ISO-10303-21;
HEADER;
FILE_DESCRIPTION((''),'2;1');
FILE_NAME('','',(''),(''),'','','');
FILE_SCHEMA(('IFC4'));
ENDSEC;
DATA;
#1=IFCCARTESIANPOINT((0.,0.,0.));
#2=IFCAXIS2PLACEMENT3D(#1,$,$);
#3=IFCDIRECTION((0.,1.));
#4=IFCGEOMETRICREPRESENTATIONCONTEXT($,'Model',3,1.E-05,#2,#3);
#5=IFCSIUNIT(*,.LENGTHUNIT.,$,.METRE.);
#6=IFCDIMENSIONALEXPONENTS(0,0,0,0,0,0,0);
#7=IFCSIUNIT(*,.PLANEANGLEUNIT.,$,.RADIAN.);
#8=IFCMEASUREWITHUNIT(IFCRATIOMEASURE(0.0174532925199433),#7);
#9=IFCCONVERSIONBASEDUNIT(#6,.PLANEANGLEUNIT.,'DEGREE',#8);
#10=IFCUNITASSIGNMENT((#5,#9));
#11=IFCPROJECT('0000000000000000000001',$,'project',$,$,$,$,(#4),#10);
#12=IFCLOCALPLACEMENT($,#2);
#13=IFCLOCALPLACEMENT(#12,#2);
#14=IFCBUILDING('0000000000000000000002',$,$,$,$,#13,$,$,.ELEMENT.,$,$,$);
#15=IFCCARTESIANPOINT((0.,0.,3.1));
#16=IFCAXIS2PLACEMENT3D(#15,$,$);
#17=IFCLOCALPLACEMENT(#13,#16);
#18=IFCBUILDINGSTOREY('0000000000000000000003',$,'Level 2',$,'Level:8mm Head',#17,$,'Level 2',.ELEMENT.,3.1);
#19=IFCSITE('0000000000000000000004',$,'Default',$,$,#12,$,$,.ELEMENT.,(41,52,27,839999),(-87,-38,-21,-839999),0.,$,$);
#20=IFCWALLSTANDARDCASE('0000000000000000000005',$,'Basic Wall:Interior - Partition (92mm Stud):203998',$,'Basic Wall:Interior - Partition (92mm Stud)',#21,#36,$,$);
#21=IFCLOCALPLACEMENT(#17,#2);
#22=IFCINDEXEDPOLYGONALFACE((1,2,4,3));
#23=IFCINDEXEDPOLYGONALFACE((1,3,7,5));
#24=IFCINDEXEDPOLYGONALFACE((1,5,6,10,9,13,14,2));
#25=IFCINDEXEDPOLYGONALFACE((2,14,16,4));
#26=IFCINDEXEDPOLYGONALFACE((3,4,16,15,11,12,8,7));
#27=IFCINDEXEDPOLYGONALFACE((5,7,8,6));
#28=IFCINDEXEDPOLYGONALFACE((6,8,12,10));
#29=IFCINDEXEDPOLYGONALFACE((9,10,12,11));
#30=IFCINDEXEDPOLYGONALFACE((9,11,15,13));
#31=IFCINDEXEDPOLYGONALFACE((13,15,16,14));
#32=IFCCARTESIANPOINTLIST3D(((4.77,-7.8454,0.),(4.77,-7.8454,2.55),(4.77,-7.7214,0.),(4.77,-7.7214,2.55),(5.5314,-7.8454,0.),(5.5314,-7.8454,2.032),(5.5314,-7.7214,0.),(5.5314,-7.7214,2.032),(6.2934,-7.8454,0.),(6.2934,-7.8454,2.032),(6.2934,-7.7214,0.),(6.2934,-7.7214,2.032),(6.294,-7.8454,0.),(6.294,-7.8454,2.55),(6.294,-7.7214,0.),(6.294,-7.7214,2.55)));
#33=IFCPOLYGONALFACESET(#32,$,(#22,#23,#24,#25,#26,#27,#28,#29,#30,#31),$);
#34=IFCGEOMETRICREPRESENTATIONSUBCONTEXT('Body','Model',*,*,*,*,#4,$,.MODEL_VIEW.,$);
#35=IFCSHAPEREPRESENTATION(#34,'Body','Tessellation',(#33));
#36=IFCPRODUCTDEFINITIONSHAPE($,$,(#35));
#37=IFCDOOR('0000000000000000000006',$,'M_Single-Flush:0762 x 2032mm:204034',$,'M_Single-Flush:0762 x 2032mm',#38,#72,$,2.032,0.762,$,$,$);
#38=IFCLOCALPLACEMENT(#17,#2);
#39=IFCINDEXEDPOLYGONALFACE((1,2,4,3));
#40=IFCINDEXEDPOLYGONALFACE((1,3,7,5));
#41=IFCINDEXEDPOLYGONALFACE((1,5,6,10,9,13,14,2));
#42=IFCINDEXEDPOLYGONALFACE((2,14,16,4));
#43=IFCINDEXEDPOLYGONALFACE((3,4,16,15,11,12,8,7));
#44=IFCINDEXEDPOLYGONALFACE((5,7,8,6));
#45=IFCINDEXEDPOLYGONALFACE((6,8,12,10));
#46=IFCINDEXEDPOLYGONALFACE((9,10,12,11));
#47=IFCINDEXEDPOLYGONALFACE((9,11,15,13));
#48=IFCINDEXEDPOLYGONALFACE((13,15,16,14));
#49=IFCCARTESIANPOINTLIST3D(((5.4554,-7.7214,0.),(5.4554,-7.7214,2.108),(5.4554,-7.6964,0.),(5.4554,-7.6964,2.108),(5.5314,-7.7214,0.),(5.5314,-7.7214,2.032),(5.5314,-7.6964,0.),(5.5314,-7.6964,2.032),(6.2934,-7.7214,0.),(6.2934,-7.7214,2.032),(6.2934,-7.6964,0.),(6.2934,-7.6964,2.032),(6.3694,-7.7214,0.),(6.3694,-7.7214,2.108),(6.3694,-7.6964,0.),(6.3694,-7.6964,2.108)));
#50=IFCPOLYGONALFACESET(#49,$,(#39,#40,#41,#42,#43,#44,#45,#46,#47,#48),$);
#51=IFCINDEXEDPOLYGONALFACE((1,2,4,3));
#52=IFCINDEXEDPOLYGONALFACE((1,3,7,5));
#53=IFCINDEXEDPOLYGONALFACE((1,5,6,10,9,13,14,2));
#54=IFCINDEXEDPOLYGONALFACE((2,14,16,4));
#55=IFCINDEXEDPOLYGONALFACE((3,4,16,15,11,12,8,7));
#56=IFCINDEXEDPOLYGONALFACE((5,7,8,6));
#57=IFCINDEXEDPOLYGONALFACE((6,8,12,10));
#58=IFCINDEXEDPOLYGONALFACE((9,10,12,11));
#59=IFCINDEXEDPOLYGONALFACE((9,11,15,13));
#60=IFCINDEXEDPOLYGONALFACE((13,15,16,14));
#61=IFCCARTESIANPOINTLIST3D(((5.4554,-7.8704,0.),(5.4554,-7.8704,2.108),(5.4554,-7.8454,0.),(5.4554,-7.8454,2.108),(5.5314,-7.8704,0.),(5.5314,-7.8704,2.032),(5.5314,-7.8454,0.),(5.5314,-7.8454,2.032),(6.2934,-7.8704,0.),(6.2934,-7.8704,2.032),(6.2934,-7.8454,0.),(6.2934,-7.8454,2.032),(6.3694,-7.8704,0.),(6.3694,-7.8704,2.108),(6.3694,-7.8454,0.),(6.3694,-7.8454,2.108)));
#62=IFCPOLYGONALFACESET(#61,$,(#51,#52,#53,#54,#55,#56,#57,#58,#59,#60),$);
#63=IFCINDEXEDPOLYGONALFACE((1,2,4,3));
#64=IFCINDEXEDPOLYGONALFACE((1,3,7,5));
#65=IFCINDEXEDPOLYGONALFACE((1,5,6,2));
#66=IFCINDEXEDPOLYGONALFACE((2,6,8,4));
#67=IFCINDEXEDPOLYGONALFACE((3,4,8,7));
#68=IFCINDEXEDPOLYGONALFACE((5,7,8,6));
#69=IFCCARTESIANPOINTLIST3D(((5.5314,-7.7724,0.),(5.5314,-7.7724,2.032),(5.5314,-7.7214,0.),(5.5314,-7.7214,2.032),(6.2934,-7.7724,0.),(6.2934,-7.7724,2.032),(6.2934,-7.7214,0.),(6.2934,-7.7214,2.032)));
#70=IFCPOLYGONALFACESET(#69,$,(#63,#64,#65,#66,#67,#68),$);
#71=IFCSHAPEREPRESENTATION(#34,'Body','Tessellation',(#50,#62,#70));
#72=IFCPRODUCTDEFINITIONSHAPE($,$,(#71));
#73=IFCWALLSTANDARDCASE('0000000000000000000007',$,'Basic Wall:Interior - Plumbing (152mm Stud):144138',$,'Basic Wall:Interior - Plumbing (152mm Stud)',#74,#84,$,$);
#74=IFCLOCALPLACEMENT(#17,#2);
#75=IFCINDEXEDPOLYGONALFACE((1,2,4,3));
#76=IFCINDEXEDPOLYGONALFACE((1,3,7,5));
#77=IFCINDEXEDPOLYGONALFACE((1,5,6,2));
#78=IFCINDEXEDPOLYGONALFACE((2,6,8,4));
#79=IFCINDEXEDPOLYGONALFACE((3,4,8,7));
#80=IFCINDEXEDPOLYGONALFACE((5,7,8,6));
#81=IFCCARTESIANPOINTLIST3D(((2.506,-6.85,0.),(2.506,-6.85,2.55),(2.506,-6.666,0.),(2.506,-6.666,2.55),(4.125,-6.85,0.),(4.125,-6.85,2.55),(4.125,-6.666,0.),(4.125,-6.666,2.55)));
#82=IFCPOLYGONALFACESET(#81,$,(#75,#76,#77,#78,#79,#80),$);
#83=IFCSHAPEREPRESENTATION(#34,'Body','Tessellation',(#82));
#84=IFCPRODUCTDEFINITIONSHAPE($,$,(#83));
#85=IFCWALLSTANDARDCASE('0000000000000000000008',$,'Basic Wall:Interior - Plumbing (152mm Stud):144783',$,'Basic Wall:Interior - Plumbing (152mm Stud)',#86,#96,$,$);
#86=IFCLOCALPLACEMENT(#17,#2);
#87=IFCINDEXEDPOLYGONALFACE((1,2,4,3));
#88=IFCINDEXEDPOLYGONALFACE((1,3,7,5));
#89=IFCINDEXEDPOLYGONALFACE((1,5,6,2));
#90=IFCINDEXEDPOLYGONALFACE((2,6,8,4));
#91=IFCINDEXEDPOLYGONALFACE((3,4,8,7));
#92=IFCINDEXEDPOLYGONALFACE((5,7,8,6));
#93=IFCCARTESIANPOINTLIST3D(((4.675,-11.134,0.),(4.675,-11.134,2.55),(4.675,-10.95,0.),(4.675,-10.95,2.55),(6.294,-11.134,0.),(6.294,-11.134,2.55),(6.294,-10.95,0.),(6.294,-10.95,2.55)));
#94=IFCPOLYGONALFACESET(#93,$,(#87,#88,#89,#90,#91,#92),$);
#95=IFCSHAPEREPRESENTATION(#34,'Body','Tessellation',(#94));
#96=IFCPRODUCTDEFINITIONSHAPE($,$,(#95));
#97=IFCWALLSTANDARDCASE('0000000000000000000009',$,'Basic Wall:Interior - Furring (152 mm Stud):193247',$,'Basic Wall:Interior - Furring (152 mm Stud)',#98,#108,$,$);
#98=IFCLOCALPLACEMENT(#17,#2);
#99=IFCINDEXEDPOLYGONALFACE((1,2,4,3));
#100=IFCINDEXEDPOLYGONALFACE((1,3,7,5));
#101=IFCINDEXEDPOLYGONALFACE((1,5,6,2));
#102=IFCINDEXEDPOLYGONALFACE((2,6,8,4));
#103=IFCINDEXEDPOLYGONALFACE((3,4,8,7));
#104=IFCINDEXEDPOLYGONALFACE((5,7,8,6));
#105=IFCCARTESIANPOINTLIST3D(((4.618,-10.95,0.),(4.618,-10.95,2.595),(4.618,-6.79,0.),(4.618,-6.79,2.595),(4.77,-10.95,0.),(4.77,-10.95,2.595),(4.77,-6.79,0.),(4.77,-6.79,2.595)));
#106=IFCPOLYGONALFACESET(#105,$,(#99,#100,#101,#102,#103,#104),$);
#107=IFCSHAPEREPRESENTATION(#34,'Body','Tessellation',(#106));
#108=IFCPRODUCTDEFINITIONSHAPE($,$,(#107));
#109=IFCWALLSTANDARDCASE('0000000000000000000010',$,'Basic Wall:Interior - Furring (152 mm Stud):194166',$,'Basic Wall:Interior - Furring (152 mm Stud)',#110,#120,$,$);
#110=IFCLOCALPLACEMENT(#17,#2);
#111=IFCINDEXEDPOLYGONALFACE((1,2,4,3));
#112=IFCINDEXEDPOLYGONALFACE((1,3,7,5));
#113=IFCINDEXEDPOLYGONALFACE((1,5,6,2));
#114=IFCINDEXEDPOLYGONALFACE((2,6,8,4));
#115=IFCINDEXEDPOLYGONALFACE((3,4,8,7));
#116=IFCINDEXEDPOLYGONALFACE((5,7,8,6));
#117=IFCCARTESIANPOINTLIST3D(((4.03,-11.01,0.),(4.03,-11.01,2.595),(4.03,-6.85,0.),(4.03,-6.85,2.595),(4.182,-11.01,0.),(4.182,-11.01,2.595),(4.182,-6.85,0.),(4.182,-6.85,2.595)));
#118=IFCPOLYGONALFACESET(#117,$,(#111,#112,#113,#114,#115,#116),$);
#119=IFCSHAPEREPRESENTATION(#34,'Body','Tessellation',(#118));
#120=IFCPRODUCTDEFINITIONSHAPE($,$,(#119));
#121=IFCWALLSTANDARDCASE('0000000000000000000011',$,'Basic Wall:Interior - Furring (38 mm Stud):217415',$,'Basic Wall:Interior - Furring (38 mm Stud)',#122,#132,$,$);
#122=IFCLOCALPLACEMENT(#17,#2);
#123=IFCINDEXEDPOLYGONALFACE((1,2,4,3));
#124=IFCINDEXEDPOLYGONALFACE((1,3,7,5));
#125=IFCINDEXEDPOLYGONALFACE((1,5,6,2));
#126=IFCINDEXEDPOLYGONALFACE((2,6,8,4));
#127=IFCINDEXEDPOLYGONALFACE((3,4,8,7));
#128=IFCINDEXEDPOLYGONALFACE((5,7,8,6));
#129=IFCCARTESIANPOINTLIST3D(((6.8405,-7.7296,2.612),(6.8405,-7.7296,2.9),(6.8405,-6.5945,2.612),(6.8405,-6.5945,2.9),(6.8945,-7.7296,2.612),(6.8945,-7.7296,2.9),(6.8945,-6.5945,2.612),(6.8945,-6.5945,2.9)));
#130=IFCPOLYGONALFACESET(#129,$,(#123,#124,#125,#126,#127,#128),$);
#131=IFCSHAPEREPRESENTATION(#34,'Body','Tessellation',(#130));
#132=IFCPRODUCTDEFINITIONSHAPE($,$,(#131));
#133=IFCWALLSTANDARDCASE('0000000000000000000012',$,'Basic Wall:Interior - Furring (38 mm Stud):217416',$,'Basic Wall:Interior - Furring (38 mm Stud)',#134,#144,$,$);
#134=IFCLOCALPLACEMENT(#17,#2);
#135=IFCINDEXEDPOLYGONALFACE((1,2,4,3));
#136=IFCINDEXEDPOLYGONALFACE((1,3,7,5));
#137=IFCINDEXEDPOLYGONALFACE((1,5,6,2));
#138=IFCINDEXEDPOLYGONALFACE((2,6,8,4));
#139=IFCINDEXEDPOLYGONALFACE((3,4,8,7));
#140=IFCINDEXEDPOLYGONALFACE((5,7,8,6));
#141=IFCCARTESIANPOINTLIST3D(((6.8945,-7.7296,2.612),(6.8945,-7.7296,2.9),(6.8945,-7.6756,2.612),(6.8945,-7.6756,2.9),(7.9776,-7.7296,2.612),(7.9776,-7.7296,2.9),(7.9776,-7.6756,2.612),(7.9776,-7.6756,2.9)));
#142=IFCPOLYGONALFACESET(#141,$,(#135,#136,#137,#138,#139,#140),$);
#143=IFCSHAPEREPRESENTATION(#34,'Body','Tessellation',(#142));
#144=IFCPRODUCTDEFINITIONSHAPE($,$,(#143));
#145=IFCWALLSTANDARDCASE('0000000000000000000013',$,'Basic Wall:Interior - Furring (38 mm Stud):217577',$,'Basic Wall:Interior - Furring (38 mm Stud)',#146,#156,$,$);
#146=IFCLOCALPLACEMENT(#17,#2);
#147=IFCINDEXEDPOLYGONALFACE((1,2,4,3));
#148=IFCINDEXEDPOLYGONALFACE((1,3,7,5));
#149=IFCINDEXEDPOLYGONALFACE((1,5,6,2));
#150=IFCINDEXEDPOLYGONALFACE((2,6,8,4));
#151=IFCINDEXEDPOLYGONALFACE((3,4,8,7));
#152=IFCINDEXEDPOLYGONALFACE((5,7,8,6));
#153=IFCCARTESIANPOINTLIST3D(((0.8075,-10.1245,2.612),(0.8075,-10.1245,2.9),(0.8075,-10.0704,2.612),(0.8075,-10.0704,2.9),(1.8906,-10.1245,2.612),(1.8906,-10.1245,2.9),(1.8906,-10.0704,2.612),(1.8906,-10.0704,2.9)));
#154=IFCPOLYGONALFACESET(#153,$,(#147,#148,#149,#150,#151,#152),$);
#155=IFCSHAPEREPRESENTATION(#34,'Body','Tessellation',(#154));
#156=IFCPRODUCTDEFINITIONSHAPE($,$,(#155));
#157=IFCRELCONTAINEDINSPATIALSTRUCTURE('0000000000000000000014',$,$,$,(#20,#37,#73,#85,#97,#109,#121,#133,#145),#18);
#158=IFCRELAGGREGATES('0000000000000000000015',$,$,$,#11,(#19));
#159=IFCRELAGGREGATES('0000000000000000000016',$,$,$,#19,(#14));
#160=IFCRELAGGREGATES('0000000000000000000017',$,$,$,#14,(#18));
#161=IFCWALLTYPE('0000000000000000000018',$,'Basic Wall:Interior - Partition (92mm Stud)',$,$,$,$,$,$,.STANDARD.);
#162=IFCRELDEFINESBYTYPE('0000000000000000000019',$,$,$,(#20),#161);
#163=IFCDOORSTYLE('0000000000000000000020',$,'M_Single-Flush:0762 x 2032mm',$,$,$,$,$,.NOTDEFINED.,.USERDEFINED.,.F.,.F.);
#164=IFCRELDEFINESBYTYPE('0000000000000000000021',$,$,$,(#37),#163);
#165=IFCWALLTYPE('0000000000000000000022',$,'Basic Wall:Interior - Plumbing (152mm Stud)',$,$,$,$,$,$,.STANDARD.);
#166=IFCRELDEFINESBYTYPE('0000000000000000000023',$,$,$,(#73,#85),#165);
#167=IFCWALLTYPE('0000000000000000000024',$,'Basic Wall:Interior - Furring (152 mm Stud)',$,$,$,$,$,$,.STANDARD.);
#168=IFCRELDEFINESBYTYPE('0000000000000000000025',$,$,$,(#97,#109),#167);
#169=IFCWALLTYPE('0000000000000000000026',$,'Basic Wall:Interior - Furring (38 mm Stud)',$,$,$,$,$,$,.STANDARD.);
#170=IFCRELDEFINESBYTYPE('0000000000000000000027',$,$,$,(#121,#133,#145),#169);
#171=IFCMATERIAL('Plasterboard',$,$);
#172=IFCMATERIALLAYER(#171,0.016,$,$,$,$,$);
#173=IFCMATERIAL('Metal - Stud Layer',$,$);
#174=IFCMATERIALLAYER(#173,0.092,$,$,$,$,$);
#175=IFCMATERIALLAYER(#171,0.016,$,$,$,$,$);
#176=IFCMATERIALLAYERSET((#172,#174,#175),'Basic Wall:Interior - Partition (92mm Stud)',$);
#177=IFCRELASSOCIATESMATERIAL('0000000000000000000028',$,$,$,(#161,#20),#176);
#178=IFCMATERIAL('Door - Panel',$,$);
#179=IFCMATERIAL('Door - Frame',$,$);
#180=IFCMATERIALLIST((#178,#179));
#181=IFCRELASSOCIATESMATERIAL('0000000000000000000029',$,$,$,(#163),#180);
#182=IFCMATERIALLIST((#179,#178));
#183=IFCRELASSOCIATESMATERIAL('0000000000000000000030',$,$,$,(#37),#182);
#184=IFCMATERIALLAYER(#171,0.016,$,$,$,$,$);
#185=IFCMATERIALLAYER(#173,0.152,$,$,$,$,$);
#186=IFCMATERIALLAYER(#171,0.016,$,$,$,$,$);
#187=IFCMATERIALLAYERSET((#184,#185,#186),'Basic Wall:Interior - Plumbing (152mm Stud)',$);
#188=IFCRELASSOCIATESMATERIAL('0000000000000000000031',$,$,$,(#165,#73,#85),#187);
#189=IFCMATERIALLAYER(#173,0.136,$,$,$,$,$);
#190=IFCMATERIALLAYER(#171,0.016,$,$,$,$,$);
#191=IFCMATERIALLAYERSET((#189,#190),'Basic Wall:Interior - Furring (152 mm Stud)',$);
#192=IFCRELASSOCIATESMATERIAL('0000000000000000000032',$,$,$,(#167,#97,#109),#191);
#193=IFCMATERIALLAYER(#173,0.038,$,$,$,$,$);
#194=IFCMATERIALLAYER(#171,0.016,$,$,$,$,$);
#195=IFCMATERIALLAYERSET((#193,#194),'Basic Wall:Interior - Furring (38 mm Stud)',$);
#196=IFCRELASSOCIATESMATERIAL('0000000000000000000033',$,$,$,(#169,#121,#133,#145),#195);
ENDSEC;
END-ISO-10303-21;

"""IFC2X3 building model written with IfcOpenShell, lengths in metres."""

from ifc_helpers import new_model, entity, si_unit, converted_unit, direction, frame, frame_2d, origin, origin_2d_with_axis, place, context, subcontext, project, spatial, polyline, rectangle, outline, extrude, source, transform, mapped, material, material_list, layer, layer_set, layer_usage, type_object, type_shapes, element, fill, save


model = new_model("IFC2X3")

# Units and contexts
model_context = context("Model", 3, precision=1e-05, world=origin(), true_north=direction((0.0, 1.0)))
body_context = subcontext(model_context, "Body", "Model", "MODEL_VIEW")
ifc_project = project(units=[si_unit("LENGTHUNIT", "METRE"), converted_unit("PLANEANGLEUNIT", "DEGREE", entity("IfcRatioMeasure", 0.0174532925199433), si_unit("PLANEANGLEUNIT", "RADIAN"), dimensions=[0, 0, 0, 0, 0, 0, 0])], contexts=[model_context])

# Site, building, storey
site_placement = place(None, origin())
site = spatial("IfcSite", under=ifc_project, at=site_placement, Name="Default", CompositionType="ELEMENT", RefLatitude=(41, 52, 27, 839999), RefLongitude=(-87, -38, -21, -839999), RefElevation=0.0)
building_placement = place(site_placement, origin())
building = spatial("IfcBuilding", under=site, at=building_placement, CompositionType="ELEMENT")
storey_placement = place(building_placement, frame((0.0, 0.0, 3.1)))
storey = spatial("IfcBuildingStorey", under=building, at=storey_placement, Name="Level 2", ObjectType="Level:8mm Head", LongName="Level 2", CompositionType="ELEMENT", Elevation=3.1)

# Shared definitions
ifc_material_1 = material(Name="Plasterboard")
ifc_layer_1 = layer(ifc_material_1, 0.016)
ifc_material_2 = material(Name="Metal - Stud Layer")
ifc_layer_2 = layer(ifc_material_2, 0.092)
ifc_layer_3 = layer(ifc_material_1, 0.016)
ifc_layer_set_1 = layer_set([ifc_layer_1, ifc_layer_2, ifc_layer_3], Name="Basic Wall:Interior - Partition (92mm Stud)")
wall_type_1 = type_object("IfcWallType", Name="Basic Wall:Interior - Partition (92mm Stud)", PredefinedType="STANDARD", material=ifc_layer_set_1)

# Wall, opening, door
ifc_material_3 = material(Name="Door - Frame")
ifc_material_4 = material(Name="Door - Panel")
ifc_material_list_1 = material_list([ifc_material_4, ifc_material_3])
door_style = type_object("IfcDoorStyle", Name="M_Single-Flush:0762 x 2032mm", ConstructionType="USERDEFINED", OperationType="NOTDEFINED", ParameterTakesPrecedence=False, Sizeable=False, material=ifc_material_list_1)
shared_shape_1 = source(origin(), body_context, "Body", "SweptSolid", [
    extrude(outline(polyline([(-0.457, -1.073), (0.457, -1.073), (0.457, 1.035), (0.381, 1.035), (0.381, -0.997), (-0.381, -0.997), (-0.381, 1.035), (-0.457, 1.035), (-0.457, -1.073)])), frame((0.381, 0.124, 1.035), z_axis=(0.0, 1.0, 0.0), x_axis=(1.0, 0.0, 0.0)), (0.0, 0.0, 1.0), 0.025),
    extrude(outline(polyline([(-1.073, -0.457), (1.035, -0.457), (1.035, -0.381), (-0.997, -0.381), (-0.997, 0.381), (1.035, 0.381), (1.035, 0.457), (-1.073, 0.457), (-1.073, -0.457)])), frame((0.381, -0.025, 1.035), z_axis=(0.0, 1.0, 0.0), x_axis=(0.0, 0.0, -1.0)), (0.0, 0.0, 1.0), 0.025),
    extrude(rectangle(XDim=0.051, YDim=0.762, at=origin_2d_with_axis()), frame((0.381, 0.0985, 0.0), z_axis=(0.0, 0.0, 1.0), x_axis=(0.0, 1.0, 0.0)), (0.0, 0.0, 1.0), 2.032),
])
type_shapes(door_style, [shared_shape_1])
ifc_layer_usage_1 = layer_usage(ifc_layer_set_1, "AXIS2", "POSITIVE", -0.062)
wall_1_placement = place(storey_placement, frame((4.77, -7.7834, 0.0)))
wall_1 = element("IfcWallStandardCase", 1, at=wall_1_placement, inside=storey, type_object=wall_type_1, material=ifc_layer_usage_1, Name="Basic Wall:Interior - Partition (92mm Stud):203998", ObjectType="Basic Wall:Interior - Partition (92mm Stud)", context=body_context, shape_type="SweptSolid", body=[
    extrude(rectangle(XDim=1.524, YDim=0.124, at=frame_2d((0.762, 0.0), x_axis=(-1.0, 0.0))), origin(), (0.0, 0.0, 1.0), 2.55),
])
opening_1_placement = place(wall_1_placement, frame((0.7614, -0.062, 0.0)))
opening_1 = element("IfcOpeningElement", 2, at=opening_1_placement, cuts=wall_1, ObjectType="Opening", context=body_context, shape_type="SweptSolid", body=[
    extrude(rectangle(XDim=0.762, YDim=2.032, at=frame_2d((1.016, 0.381), x_axis=(0.0, 1.0))), frame((0.0, 0.0, 0.0), z_axis=(0.0, 1.0, 0.0), x_axis=(0.0, 0.0, 1.0)), (0.0, 0.0, 1.0), 0.124),
])
ifc_material_list_2 = material_list([ifc_material_3, ifc_material_4])
door_1_placement = place(opening_1_placement, origin())
door_1 = element("IfcDoor", 3, at=door_1_placement, inside=storey, type_object=door_style, material=ifc_material_list_2, Name="M_Single-Flush:0762 x 2032mm:204034", ObjectType="M_Single-Flush:0762 x 2032mm", OverallHeight=2.032, OverallWidth=0.762, context=body_context, shape_type="MappedRepresentation", body=[
    mapped(shared_shape_1, transform((0.0, 0.0, 0.0), scale=1.0)),
])
fill(opening_1, door_1)

# Walls
ifc_layer_4 = layer(ifc_material_1, 0.016)
ifc_layer_5 = layer(ifc_material_2, 0.152)
ifc_layer_6 = layer(ifc_material_1, 0.016)
ifc_layer_set_2 = layer_set([ifc_layer_4, ifc_layer_5, ifc_layer_6], Name="Basic Wall:Interior - Plumbing (152mm Stud)")
ifc_layer_usage_2 = layer_usage(ifc_layer_set_2, "AXIS2", "NEGATIVE", 0.092)
wall_type_2 = type_object("IfcWallType", Name="Basic Wall:Interior - Plumbing (152mm Stud)", PredefinedType="STANDARD", material=ifc_layer_set_2)
wall_2_placement = place(storey_placement, frame((2.506, -6.758, 0.0)))
element("IfcWallStandardCase", 4, at=wall_2_placement, inside=storey, type_object=wall_type_2, material=ifc_layer_usage_2, Name="Basic Wall:Interior - Plumbing (152mm Stud):144138", ObjectType="Basic Wall:Interior - Plumbing (152mm Stud)", context=body_context, shape_type="SweptSolid", body=[
    extrude(rectangle(XDim=1.619, YDim=0.184, at=frame_2d((0.8095, 0.0), x_axis=(-1.0, 0.0))), origin(), (0.0, 0.0, 1.0), 2.55),
])
ifc_layer_usage_3 = layer_usage(ifc_layer_set_2, "AXIS2", "NEGATIVE", 0.092)
wall_3_placement = place(storey_placement, frame((6.294, -11.042, 0.0), z_axis=(0.0, 0.0, 1.0), x_axis=(-1.0, 0.0, 0.0)))
element("IfcWallStandardCase", 5, at=wall_3_placement, inside=storey, type_object=wall_type_2, material=ifc_layer_usage_3, Name="Basic Wall:Interior - Plumbing (152mm Stud):144783", ObjectType="Basic Wall:Interior - Plumbing (152mm Stud)", context=body_context, shape_type="SweptSolid", body=[
    extrude(rectangle(XDim=1.619, YDim=0.184, at=frame_2d((0.8095, 0.0), x_axis=(-1.0, 0.0))), origin(), (0.0, 0.0, 1.0), 2.55),
])
ifc_layer_7 = layer(ifc_material_2, 0.136)
ifc_layer_8 = layer(ifc_material_1, 0.016)
ifc_layer_set_3 = layer_set([ifc_layer_7, ifc_layer_8], Name="Basic Wall:Interior - Furring (152 mm Stud)")
ifc_layer_usage_4 = layer_usage(ifc_layer_set_3, "AXIS2", "POSITIVE", -0.076)
wall_type_3 = type_object("IfcWallType", Name="Basic Wall:Interior - Furring (152 mm Stud)", PredefinedType="STANDARD", material=ifc_layer_set_3)
wall_4_placement = place(storey_placement, frame((4.694, -6.79, 0.0), z_axis=(0.0, 0.0, 1.0), x_axis=(0.0, -1.0, 0.0)))
element("IfcWallStandardCase", 6, at=wall_4_placement, inside=storey, type_object=wall_type_3, material=ifc_layer_usage_4, Name="Basic Wall:Interior - Furring (152 mm Stud):193247", ObjectType="Basic Wall:Interior - Furring (152 mm Stud)", context=body_context, shape_type="SweptSolid", body=[
    extrude(rectangle(XDim=4.16, YDim=0.152, at=frame_2d((2.08, 0.0), x_axis=(-1.0, 0.0))), origin(), (0.0, 0.0, 1.0), 2.595),
])
ifc_layer_usage_5 = layer_usage(ifc_layer_set_3, "AXIS2", "POSITIVE", -0.076)
wall_5_placement = place(storey_placement, frame((4.106, -11.01, 0.0), z_axis=(0.0, 0.0, 1.0), x_axis=(0.0, 1.0, 0.0)))
element("IfcWallStandardCase", 7, at=wall_5_placement, inside=storey, type_object=wall_type_3, material=ifc_layer_usage_5, Name="Basic Wall:Interior - Furring (152 mm Stud):194166", ObjectType="Basic Wall:Interior - Furring (152 mm Stud)", context=body_context, shape_type="SweptSolid", body=[
    extrude(rectangle(XDim=4.16, YDim=0.152, at=frame_2d((2.08, 0.0), x_axis=(-1.0, 0.0))), origin(), (0.0, 0.0, 1.0), 2.595),
])
ifc_layer_9 = layer(ifc_material_2, 0.038)
ifc_layer_10 = layer(ifc_material_1, 0.016)
ifc_layer_set_4 = layer_set([ifc_layer_9, ifc_layer_10], Name="Basic Wall:Interior - Furring (38 mm Stud)")
ifc_layer_usage_6 = layer_usage(ifc_layer_set_4, "AXIS2", "NEGATIVE", 0.027)
wall_type_4 = type_object("IfcWallType", Name="Basic Wall:Interior - Furring (38 mm Stud)", PredefinedType="STANDARD", material=ifc_layer_set_4)
wall_6_placement = place(storey_placement, frame((6.8675, -7.7296, 2.612), z_axis=(0.0, 0.0, 1.0), x_axis=(0.0, 1.0, 0.0)))
element("IfcWallStandardCase", 8, at=wall_6_placement, inside=storey, type_object=wall_type_4, material=ifc_layer_usage_6, Name="Basic Wall:Interior - Furring (38 mm Stud):217415", ObjectType="Basic Wall:Interior - Furring (38 mm Stud)", context=body_context, shape_type="SweptSolid", body=[
    extrude(rectangle(XDim=1.1351, YDim=0.054, at=frame_2d((0.5675, 0.0), x_axis=(-1.0, 0.0))), origin(), (0.0, 0.0, 1.0), 0.288),
])
ifc_layer_usage_7 = layer_usage(ifc_layer_set_4, "AXIS2", "NEGATIVE", 0.027)
wall_7_placement = place(storey_placement, frame((7.9776, -7.7026, 2.612), z_axis=(0.0, 0.0, 1.0), x_axis=(-1.0, 0.0, 0.0)))
element("IfcWallStandardCase", 9, at=wall_7_placement, inside=storey, type_object=wall_type_4, material=ifc_layer_usage_7, Name="Basic Wall:Interior - Furring (38 mm Stud):217416", ObjectType="Basic Wall:Interior - Furring (38 mm Stud)", context=body_context, shape_type="SweptSolid", body=[
    extrude(rectangle(XDim=1.0831, YDim=0.054, at=frame_2d((0.5415, 0.0), x_axis=(-1.0, 0.0))), origin(), (0.0, 0.0, 1.0), 0.288),
])
ifc_layer_usage_8 = layer_usage(ifc_layer_set_4, "AXIS2", "NEGATIVE", 0.027)
wall_8_placement = place(storey_placement, frame((0.8075, -10.0975, 2.612)))
element("IfcWallStandardCase", 10, at=wall_8_placement, inside=storey, type_object=wall_type_4, material=ifc_layer_usage_8, Name="Basic Wall:Interior - Furring (38 mm Stud):217577", ObjectType="Basic Wall:Interior - Furring (38 mm Stud)", context=body_context, shape_type="SweptSolid", body=[
    extrude(rectangle(XDim=1.0831, YDim=0.054, at=frame_2d((0.5415, 0.0), x_axis=(-1.0, 0.0))), origin(), (0.0, 0.0, 1.0), 0.288),
])

save(model, "model.ifc")
